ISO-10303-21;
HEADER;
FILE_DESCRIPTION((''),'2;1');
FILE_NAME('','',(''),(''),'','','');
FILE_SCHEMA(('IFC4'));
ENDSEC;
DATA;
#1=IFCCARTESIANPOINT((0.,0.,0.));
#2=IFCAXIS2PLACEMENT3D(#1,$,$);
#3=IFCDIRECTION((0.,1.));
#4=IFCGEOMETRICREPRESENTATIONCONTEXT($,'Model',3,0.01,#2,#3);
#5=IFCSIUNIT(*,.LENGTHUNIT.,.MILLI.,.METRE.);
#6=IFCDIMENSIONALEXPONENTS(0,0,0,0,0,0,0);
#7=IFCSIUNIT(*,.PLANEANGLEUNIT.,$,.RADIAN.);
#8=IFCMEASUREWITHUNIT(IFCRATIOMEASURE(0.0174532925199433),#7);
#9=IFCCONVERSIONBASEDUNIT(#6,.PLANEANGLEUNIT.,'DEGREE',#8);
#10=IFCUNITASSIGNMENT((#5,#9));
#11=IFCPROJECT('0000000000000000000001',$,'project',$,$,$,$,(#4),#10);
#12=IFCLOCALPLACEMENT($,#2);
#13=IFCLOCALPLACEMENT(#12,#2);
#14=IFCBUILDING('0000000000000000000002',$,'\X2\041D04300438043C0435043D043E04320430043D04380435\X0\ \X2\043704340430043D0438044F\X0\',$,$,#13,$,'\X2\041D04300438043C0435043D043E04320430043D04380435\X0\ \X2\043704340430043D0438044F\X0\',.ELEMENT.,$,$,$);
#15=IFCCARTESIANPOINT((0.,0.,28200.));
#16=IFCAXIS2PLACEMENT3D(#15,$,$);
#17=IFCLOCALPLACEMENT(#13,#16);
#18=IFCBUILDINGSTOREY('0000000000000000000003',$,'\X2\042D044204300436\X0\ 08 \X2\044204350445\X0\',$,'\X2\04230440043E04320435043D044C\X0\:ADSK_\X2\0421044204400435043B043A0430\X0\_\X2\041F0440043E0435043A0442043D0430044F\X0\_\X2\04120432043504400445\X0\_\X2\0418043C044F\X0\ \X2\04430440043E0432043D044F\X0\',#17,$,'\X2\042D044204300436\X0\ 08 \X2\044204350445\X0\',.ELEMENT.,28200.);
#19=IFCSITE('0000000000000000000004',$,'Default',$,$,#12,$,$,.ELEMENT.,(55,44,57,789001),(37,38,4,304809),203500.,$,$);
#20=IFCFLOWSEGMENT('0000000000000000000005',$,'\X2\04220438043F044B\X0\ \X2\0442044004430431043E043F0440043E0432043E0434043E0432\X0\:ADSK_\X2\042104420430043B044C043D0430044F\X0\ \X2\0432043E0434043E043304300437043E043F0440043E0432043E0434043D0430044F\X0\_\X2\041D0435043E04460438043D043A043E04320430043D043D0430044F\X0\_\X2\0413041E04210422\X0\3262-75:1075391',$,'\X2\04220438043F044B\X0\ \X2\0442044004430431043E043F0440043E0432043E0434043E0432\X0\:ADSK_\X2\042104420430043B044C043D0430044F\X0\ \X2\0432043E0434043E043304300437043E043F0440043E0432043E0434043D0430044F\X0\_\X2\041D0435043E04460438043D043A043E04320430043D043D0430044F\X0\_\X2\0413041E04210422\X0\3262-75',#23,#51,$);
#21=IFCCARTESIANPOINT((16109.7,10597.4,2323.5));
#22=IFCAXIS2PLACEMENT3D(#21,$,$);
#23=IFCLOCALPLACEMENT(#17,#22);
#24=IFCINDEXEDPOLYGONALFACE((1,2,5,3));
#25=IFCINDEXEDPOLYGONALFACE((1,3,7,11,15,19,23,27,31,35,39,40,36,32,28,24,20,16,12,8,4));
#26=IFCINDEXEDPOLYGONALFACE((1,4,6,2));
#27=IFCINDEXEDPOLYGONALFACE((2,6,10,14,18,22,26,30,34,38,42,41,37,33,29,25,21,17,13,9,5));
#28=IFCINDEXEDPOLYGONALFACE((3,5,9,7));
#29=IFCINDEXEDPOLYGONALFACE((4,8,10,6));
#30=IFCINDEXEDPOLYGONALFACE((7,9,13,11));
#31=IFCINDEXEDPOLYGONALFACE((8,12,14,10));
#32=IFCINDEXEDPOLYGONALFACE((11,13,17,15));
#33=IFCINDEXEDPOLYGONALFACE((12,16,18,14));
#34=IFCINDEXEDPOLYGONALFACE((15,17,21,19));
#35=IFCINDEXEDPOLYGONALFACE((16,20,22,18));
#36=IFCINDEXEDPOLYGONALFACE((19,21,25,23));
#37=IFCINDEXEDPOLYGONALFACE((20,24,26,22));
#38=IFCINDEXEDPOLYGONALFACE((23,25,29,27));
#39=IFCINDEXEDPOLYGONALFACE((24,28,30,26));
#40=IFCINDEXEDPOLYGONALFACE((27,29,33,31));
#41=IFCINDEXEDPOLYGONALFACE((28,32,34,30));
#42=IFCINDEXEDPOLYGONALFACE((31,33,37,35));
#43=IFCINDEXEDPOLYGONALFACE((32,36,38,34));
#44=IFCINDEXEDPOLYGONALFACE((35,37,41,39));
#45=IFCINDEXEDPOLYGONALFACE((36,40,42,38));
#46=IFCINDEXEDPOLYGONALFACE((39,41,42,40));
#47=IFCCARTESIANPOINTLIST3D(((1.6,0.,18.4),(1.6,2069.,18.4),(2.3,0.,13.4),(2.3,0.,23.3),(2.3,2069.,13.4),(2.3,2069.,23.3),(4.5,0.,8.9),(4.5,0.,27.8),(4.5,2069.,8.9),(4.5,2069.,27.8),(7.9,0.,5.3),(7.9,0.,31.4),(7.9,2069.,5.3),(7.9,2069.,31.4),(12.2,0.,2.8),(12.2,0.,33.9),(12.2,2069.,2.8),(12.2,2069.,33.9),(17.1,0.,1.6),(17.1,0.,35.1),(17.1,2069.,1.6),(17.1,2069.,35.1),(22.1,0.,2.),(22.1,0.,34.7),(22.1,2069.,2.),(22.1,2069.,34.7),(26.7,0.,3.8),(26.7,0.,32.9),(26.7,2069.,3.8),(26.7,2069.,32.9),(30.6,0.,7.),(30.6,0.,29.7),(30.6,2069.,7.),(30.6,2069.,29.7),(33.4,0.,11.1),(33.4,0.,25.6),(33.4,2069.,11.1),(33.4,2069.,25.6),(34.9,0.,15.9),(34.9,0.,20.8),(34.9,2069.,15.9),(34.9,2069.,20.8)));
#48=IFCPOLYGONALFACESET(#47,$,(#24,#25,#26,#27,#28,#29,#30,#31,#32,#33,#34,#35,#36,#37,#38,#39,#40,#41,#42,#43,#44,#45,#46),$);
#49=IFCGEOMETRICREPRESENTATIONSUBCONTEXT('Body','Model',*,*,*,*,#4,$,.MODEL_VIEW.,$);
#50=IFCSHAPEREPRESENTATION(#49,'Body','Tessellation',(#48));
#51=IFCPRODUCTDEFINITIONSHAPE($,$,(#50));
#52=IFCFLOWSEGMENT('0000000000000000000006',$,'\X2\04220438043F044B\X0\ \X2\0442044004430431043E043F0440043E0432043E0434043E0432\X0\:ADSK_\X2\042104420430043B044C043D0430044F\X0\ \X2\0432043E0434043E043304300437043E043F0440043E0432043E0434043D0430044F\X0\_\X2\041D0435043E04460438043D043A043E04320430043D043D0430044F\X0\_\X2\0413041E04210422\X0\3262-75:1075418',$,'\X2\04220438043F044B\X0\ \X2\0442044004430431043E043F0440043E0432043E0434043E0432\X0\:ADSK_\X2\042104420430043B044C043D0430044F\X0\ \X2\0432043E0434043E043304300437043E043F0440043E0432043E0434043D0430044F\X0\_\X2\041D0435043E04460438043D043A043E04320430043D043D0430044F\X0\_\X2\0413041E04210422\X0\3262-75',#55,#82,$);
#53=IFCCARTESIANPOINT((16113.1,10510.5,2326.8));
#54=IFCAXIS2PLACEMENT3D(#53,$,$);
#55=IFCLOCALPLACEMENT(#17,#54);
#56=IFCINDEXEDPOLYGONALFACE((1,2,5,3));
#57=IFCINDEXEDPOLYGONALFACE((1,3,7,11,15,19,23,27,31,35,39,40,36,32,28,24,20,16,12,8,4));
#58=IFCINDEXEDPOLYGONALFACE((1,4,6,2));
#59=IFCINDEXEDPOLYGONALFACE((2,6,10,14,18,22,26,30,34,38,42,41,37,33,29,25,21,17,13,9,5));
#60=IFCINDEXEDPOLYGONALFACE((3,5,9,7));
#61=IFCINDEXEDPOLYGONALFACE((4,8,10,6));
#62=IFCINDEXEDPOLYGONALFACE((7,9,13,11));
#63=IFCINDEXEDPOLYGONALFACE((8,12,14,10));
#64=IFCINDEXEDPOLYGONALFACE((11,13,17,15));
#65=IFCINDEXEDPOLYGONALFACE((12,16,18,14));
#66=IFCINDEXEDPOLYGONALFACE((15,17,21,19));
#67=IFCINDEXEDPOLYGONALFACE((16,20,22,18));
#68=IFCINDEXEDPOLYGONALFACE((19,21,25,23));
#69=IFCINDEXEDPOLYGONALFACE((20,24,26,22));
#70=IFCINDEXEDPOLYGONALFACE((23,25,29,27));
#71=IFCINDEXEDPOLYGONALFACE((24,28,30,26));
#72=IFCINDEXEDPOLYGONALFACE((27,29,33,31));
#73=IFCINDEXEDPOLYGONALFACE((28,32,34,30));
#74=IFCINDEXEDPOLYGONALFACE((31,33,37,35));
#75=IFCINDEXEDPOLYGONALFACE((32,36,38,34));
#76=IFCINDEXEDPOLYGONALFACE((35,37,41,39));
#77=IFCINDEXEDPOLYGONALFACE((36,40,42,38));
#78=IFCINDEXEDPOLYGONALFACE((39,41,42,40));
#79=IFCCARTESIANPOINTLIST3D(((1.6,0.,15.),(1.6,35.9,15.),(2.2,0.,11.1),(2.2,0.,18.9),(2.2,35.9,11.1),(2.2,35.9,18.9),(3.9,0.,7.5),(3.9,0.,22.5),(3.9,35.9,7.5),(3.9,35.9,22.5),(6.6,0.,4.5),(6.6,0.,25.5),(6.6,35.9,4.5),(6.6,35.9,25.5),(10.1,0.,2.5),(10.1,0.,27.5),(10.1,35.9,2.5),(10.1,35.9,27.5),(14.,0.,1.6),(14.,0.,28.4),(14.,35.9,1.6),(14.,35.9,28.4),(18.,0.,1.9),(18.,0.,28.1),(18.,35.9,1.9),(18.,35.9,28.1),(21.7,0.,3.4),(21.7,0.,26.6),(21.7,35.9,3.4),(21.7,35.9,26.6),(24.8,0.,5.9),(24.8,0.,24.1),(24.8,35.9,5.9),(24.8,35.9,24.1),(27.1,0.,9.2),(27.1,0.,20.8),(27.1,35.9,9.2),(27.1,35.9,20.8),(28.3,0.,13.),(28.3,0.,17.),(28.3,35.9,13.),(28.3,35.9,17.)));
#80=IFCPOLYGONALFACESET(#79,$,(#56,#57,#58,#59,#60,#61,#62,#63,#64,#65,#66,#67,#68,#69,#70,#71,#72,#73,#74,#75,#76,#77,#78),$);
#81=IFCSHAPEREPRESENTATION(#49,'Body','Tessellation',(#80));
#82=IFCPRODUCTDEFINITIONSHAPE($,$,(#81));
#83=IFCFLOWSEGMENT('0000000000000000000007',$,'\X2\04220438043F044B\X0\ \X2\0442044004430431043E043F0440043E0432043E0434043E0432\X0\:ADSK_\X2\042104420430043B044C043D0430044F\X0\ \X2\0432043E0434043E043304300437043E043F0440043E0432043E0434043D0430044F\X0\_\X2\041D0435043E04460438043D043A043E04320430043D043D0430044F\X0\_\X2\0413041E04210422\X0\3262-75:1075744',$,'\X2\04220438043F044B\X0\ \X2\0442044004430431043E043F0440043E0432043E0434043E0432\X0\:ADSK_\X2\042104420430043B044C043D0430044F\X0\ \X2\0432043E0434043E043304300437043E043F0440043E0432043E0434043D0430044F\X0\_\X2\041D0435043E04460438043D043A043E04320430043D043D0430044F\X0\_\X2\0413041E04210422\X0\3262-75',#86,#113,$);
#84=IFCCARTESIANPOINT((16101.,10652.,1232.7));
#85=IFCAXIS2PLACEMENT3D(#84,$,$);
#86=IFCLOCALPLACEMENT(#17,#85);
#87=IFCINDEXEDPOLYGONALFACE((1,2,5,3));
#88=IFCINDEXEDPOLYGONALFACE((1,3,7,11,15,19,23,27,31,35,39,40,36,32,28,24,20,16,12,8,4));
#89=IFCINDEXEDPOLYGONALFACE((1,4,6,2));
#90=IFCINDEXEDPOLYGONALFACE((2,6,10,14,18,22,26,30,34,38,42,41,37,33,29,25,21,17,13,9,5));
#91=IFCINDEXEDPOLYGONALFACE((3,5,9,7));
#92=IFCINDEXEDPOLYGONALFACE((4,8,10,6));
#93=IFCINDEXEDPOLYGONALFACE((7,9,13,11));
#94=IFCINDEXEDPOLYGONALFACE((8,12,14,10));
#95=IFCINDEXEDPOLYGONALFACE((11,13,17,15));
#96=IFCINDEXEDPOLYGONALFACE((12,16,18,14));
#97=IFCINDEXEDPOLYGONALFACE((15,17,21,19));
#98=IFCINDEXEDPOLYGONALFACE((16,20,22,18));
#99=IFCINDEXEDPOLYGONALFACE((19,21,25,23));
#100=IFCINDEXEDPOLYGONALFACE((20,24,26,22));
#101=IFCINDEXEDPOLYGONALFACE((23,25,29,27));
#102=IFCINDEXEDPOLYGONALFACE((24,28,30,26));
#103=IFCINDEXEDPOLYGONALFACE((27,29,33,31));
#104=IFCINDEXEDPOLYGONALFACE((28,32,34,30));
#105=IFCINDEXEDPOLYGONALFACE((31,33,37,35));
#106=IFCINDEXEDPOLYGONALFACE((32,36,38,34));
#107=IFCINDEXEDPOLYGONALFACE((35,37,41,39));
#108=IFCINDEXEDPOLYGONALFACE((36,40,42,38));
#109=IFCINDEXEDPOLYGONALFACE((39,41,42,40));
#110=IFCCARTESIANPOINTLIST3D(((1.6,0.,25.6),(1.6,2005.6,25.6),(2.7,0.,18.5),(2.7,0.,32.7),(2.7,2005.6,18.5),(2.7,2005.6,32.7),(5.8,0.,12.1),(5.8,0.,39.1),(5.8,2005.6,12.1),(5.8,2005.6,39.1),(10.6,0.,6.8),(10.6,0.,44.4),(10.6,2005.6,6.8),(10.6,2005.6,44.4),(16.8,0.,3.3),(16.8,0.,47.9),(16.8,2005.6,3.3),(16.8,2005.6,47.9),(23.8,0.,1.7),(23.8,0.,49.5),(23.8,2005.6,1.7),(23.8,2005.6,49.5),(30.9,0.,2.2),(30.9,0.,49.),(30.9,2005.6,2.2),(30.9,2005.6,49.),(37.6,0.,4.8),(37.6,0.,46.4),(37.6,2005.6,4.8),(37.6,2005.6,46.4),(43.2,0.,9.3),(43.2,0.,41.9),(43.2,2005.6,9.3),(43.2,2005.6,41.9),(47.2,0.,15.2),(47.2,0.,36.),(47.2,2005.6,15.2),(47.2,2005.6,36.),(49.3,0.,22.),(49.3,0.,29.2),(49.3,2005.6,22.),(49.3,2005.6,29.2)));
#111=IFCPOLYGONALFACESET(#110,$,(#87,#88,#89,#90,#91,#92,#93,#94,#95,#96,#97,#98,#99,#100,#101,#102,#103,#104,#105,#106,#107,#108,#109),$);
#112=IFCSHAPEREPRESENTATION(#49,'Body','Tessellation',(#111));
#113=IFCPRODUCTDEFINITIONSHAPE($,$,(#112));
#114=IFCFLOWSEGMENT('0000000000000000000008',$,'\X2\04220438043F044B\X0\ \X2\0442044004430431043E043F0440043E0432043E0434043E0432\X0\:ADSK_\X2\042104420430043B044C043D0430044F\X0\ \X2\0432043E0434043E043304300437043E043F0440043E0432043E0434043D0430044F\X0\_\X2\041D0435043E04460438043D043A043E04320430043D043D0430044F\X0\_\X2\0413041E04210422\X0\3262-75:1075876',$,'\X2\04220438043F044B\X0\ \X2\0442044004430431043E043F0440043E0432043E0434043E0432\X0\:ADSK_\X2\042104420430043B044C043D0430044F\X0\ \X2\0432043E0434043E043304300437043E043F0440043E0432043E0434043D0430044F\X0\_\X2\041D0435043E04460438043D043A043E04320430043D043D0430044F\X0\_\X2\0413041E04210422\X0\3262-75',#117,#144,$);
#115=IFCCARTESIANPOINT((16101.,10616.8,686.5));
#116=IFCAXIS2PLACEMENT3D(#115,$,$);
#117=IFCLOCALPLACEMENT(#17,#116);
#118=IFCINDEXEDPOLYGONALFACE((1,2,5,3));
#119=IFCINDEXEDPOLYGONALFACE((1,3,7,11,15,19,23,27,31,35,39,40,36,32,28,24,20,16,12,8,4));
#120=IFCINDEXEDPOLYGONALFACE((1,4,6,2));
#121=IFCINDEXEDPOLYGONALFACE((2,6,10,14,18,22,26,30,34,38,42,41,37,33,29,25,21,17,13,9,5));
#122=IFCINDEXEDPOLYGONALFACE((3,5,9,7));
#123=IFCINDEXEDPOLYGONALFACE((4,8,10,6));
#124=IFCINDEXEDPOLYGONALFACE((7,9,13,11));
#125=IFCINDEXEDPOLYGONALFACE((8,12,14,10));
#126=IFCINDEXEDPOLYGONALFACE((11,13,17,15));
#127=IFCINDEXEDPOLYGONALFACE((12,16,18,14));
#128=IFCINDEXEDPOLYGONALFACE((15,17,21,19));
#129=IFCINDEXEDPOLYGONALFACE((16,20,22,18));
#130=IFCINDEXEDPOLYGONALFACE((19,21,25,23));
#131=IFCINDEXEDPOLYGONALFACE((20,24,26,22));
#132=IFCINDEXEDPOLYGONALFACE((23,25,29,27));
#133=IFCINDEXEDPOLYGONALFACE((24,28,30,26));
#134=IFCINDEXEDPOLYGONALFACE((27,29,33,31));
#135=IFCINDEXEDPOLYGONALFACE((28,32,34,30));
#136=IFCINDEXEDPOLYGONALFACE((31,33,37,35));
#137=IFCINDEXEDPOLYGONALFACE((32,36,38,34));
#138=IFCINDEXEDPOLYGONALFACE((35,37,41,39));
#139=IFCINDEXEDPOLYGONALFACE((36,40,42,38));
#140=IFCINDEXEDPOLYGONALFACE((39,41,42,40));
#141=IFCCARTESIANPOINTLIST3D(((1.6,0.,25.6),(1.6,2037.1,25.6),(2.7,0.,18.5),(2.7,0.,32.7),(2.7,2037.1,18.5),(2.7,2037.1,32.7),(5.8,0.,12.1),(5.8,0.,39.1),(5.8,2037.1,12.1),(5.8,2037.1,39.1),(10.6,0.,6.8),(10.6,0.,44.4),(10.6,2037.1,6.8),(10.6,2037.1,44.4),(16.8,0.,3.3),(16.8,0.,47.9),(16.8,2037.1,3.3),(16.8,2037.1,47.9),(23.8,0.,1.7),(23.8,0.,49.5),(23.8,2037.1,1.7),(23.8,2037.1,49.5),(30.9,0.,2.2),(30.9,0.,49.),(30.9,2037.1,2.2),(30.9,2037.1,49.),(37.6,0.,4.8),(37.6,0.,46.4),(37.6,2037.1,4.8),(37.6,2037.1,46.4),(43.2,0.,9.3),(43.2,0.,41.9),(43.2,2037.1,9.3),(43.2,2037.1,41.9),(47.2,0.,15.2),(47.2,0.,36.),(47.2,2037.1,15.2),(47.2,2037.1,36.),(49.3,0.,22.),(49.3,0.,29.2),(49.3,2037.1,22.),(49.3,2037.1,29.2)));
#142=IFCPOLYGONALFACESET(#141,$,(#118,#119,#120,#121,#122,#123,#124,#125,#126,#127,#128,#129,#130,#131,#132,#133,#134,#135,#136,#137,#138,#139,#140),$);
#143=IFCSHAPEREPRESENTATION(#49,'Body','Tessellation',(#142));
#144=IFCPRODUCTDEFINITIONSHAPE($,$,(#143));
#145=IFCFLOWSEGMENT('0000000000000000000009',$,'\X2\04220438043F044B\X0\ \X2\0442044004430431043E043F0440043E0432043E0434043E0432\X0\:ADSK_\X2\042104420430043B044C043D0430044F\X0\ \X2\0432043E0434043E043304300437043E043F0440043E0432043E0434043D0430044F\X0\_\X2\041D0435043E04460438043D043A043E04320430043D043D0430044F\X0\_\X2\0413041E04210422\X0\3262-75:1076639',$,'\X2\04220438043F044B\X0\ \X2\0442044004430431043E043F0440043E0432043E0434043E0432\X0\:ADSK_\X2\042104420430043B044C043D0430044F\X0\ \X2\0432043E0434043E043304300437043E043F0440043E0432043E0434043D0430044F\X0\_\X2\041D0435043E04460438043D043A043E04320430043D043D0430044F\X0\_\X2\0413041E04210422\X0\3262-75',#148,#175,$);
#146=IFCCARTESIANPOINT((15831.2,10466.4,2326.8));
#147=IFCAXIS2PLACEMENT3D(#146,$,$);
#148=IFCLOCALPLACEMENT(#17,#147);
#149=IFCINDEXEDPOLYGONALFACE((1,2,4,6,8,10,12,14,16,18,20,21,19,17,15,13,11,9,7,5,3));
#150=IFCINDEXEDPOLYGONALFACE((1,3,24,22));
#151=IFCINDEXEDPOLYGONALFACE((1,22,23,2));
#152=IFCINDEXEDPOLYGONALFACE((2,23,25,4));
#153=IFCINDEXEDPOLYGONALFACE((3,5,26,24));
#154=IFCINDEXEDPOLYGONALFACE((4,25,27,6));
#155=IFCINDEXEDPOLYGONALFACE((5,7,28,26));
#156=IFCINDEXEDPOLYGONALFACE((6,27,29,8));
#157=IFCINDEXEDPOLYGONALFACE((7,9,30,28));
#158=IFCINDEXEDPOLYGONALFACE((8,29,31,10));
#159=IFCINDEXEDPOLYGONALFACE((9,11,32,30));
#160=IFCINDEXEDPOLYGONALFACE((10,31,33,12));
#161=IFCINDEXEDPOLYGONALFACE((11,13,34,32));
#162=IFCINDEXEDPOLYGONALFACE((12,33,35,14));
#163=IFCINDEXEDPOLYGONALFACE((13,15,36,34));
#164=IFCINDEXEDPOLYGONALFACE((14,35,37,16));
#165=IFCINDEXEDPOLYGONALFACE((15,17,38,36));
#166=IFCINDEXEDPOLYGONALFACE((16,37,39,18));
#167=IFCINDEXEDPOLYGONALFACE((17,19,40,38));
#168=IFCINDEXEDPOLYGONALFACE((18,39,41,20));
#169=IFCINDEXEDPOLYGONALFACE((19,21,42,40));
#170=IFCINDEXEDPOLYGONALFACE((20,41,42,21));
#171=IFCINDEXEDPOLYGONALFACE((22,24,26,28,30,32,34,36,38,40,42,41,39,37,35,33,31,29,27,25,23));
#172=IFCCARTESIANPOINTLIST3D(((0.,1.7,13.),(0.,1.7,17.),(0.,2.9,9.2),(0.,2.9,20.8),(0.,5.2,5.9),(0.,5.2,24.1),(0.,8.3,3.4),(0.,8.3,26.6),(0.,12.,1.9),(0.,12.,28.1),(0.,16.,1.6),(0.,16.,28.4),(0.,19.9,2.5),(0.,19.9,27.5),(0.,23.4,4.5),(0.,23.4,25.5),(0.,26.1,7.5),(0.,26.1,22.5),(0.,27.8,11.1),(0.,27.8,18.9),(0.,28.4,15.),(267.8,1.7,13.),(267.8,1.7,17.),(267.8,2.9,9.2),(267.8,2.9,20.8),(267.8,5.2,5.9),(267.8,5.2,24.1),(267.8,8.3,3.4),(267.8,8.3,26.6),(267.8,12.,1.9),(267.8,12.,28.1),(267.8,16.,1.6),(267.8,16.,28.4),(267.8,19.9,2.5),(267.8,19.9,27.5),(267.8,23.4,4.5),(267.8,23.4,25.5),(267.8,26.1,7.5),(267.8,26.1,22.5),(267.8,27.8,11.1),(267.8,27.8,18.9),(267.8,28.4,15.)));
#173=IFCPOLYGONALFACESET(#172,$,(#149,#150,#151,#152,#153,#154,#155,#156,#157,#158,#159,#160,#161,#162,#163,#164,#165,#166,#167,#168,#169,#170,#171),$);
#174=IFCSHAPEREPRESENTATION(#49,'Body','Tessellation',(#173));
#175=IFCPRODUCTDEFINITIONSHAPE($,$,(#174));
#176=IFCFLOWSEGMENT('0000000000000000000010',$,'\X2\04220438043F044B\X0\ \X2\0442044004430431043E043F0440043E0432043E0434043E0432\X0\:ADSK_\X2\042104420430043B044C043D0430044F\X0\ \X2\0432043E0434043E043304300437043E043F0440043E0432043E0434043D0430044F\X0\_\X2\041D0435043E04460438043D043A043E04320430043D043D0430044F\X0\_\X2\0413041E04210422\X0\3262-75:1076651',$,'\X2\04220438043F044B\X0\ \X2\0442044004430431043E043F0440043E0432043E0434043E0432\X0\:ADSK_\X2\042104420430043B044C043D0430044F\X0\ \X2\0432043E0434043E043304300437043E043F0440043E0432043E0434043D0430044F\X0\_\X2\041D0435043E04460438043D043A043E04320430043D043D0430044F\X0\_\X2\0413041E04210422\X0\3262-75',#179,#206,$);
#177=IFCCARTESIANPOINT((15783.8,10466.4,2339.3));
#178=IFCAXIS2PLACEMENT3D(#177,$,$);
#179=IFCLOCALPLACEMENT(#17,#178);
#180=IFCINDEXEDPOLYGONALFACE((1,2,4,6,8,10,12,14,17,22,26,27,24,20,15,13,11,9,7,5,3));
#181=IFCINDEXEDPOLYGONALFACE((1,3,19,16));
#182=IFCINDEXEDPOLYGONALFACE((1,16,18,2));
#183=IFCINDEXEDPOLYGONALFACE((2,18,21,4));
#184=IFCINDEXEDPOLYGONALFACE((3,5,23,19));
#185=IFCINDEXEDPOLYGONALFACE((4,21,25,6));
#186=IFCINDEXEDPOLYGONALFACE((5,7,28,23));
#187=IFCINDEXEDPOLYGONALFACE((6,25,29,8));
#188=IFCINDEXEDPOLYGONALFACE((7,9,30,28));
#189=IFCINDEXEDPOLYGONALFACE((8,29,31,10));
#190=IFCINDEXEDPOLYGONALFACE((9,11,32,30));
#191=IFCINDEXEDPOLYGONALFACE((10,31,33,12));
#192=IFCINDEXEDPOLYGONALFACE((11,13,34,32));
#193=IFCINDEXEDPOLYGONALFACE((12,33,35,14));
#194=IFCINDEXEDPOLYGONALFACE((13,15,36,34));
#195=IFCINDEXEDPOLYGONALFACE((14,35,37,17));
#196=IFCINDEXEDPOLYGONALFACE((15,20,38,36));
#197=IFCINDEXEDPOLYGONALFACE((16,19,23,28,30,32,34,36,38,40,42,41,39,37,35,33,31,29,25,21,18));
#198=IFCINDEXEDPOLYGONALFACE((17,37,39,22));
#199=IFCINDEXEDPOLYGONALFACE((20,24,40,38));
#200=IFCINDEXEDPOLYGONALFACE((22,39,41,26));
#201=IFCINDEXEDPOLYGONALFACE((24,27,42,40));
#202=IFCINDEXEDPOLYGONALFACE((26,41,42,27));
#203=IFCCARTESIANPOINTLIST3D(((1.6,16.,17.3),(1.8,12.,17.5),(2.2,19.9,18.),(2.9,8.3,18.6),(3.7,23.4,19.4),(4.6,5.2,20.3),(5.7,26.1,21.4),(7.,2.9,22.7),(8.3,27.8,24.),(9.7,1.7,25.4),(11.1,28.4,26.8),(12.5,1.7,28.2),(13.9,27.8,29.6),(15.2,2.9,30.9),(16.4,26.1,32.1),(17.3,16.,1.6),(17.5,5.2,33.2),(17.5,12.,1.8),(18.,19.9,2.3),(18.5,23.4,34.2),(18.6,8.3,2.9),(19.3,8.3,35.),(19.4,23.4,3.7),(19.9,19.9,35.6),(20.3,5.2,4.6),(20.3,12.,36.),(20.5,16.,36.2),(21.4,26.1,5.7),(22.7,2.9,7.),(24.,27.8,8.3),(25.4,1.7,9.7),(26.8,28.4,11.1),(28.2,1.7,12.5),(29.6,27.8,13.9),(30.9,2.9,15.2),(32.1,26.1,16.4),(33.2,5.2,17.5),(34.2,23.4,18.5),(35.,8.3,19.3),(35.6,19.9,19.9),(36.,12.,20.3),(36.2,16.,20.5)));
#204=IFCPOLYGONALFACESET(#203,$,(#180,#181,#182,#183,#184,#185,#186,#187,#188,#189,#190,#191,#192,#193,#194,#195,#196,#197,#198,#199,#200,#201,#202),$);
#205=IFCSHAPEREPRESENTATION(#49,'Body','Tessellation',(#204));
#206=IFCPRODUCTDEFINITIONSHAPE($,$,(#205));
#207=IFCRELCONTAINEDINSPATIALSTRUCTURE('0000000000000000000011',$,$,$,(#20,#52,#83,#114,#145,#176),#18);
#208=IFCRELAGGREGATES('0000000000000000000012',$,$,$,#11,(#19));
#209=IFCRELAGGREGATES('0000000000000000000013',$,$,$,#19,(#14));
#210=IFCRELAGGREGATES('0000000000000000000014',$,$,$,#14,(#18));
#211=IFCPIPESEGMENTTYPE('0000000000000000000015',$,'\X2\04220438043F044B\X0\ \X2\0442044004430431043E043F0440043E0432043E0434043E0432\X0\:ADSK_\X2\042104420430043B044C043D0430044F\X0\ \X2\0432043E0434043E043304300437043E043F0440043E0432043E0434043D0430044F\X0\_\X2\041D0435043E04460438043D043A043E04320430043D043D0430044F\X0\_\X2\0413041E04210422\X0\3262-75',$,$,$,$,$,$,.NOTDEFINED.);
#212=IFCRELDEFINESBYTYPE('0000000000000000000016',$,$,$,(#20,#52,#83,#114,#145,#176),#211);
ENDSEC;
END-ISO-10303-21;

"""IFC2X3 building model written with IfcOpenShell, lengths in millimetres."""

from ifc_helpers import new_model, entity, si_unit, converted_unit, direction, frame, origin, origin_2d_with_axis, place, context, subcontext, project, spatial, circle, extrude, type_object, element, save


model = new_model("IFC2X3")

# Units and contexts
model_context = context("Model", 3, precision=0.01, world=origin(), true_north=direction((0.0, 1.0)))
body_context = subcontext(model_context, "Body", "Model", "MODEL_VIEW")
ifc_project = project(units=[si_unit("LENGTHUNIT", "METRE", prefix="MILLI"), converted_unit("PLANEANGLEUNIT", "DEGREE", entity("IfcRatioMeasure", 0.0174532925199433), si_unit("PLANEANGLEUNIT", "RADIAN"), dimensions=[0, 0, 0, 0, 0, 0, 0])], contexts=[model_context])

# Site, building, storey
site_placement = place(None, origin())
site = spatial("IfcSite", under=ifc_project, at=site_placement, Name="Default", CompositionType="ELEMENT", RefLatitude=(55, 44, 57, 789001), RefLongitude=(37, 38, 4, 304809), RefElevation=203500.0)
building_placement = place(site_placement, origin())
building = spatial("IfcBuilding", under=site, at=building_placement, Name="Наименование здания", LongName="Наименование здания", CompositionType="ELEMENT")
storey_placement = place(building_placement, frame((0.0, 0.0, 28200.0)))
storey = spatial("IfcBuildingStorey", under=building, at=storey_placement, Name="Этаж 08 тех", ObjectType="Уровень:ADSK_Стрелка_Проектная_Вверх_Имя уровня", LongName="Этаж 08 тех", CompositionType="ELEMENT", Elevation=28200.0)

# Flow segments
pipe_segment_type = type_object("IfcPipeSegmentType", Name="Типы трубопроводов:ADSK_Стальная водогазопроводная_Неоцинкованная_ГОСТ3262-75", PredefinedType="NOTDEFINED")
flow_segment_1_placement = place(storey_placement, frame((16109.7, 10597.4, 2323.5)))
element("IfcFlowSegment", 1, at=flow_segment_1_placement, inside=storey, type_object=pipe_segment_type, Name="Типы трубопроводов:ADSK_Стальная водогазопроводная_Неоцинкованная_ГОСТ3262-75:1075391", ObjectType="Типы трубопроводов:ADSK_Стальная водогазопроводная_Неоцинкованная_ГОСТ3262-75", context=body_context, shape_type="SweptSolid", body=[
    extrude(circle(Radius=16.8, at=origin_2d_with_axis()), frame((18.4, 0.0, 18.4), z_axis=(0.0, 1.0, 0.0), x_axis=(-1.0, 0.0, 0.0)), (0.0, 0.0, 1.0), 2069.0),
])
flow_segment_2_placement = place(storey_placement, frame((16113.1, 10510.5, 2326.8)))
element("IfcFlowSegment", 2, at=flow_segment_2_placement, inside=storey, type_object=pipe_segment_type, Name="Типы трубопроводов:ADSK_Стальная водогазопроводная_Неоцинкованная_ГОСТ3262-75:1075418", ObjectType="Типы трубопроводов:ADSK_Стальная водогазопроводная_Неоцинкованная_ГОСТ3262-75", context=body_context, shape_type="SweptSolid", body=[
    extrude(circle(Radius=13.4, at=origin_2d_with_axis()), frame((15.0, 0.0, 15.0), z_axis=(0.0, 1.0, 0.0), x_axis=(-1.0, 0.0, 0.0)), (0.0, 0.0, 1.0), 35.9),
])
flow_segment_3_placement = place(storey_placement, frame((16101.0, 10652.0, 1232.7)))
element("IfcFlowSegment", 3, at=flow_segment_3_placement, inside=storey, type_object=pipe_segment_type, Name="Типы трубопроводов:ADSK_Стальная водогазопроводная_Неоцинкованная_ГОСТ3262-75:1075744", ObjectType="Типы трубопроводов:ADSK_Стальная водогазопроводная_Неоцинкованная_ГОСТ3262-75", context=body_context, shape_type="SweptSolid", body=[
    extrude(circle(Radius=24.0, at=origin_2d_with_axis()), frame((25.6, 0.0, 25.6), z_axis=(0.0, 1.0, 0.0), x_axis=(-1.0, 0.0, 0.0)), (0.0, 0.0, 1.0), 2005.6),
])
flow_segment_4_placement = place(storey_placement, frame((16101.0, 10616.8, 686.5)))
element("IfcFlowSegment", 4, at=flow_segment_4_placement, inside=storey, type_object=pipe_segment_type, Name="Типы трубопроводов:ADSK_Стальная водогазопроводная_Неоцинкованная_ГОСТ3262-75:1075876", ObjectType="Типы трубопроводов:ADSK_Стальная водогазопроводная_Неоцинкованная_ГОСТ3262-75", context=body_context, shape_type="SweptSolid", body=[
    extrude(circle(Radius=24.0, at=origin_2d_with_axis()), frame((25.6, 0.0, 25.6), z_axis=(0.0, 1.0, 0.0), x_axis=(-1.0, 0.0, 0.0)), (0.0, 0.0, 1.0), 2037.1),
])
flow_segment_5_placement = place(storey_placement, frame((15831.2, 10466.4, 2326.8)))
element("IfcFlowSegment", 5, at=flow_segment_5_placement, inside=storey, type_object=pipe_segment_type, Name="Типы трубопроводов:ADSK_Стальная водогазопроводная_Неоцинкованная_ГОСТ3262-75:1076639", ObjectType="Типы трубопроводов:ADSK_Стальная водогазопроводная_Неоцинкованная_ГОСТ3262-75", context=body_context, shape_type="SweptSolid", body=[
    extrude(circle(Radius=13.4, at=origin_2d_with_axis()), frame((0.0, 15.0, 15.0), z_axis=(1.0, 0.0, 0.0), x_axis=(0.0, 1.0, 0.0)), (0.0, 0.0, 1.0), 267.8),
])
flow_segment_6_placement = place(storey_placement, frame((15783.8, 10466.4, 2339.3)))
element("IfcFlowSegment", 6, at=flow_segment_6_placement, inside=storey, type_object=pipe_segment_type, Name="Типы трубопроводов:ADSK_Стальная водогазопроводная_Неоцинкованная_ГОСТ3262-75:1076651", ObjectType="Типы трубопроводов:ADSK_Стальная водогазопроводная_Неоцинкованная_ГОСТ3262-75", context=body_context, shape_type="SweptSolid", body=[
    extrude(circle(Radius=13.4, at=origin_2d_with_axis()), frame((11.1, 15.0, 26.8), z_axis=(0.707107, 0.0, -0.707107), x_axis=(0.0, 1.0, 0.0)), (0.0, 0.0, 1.0), 22.2),
])

save(model, "model.ifc")
